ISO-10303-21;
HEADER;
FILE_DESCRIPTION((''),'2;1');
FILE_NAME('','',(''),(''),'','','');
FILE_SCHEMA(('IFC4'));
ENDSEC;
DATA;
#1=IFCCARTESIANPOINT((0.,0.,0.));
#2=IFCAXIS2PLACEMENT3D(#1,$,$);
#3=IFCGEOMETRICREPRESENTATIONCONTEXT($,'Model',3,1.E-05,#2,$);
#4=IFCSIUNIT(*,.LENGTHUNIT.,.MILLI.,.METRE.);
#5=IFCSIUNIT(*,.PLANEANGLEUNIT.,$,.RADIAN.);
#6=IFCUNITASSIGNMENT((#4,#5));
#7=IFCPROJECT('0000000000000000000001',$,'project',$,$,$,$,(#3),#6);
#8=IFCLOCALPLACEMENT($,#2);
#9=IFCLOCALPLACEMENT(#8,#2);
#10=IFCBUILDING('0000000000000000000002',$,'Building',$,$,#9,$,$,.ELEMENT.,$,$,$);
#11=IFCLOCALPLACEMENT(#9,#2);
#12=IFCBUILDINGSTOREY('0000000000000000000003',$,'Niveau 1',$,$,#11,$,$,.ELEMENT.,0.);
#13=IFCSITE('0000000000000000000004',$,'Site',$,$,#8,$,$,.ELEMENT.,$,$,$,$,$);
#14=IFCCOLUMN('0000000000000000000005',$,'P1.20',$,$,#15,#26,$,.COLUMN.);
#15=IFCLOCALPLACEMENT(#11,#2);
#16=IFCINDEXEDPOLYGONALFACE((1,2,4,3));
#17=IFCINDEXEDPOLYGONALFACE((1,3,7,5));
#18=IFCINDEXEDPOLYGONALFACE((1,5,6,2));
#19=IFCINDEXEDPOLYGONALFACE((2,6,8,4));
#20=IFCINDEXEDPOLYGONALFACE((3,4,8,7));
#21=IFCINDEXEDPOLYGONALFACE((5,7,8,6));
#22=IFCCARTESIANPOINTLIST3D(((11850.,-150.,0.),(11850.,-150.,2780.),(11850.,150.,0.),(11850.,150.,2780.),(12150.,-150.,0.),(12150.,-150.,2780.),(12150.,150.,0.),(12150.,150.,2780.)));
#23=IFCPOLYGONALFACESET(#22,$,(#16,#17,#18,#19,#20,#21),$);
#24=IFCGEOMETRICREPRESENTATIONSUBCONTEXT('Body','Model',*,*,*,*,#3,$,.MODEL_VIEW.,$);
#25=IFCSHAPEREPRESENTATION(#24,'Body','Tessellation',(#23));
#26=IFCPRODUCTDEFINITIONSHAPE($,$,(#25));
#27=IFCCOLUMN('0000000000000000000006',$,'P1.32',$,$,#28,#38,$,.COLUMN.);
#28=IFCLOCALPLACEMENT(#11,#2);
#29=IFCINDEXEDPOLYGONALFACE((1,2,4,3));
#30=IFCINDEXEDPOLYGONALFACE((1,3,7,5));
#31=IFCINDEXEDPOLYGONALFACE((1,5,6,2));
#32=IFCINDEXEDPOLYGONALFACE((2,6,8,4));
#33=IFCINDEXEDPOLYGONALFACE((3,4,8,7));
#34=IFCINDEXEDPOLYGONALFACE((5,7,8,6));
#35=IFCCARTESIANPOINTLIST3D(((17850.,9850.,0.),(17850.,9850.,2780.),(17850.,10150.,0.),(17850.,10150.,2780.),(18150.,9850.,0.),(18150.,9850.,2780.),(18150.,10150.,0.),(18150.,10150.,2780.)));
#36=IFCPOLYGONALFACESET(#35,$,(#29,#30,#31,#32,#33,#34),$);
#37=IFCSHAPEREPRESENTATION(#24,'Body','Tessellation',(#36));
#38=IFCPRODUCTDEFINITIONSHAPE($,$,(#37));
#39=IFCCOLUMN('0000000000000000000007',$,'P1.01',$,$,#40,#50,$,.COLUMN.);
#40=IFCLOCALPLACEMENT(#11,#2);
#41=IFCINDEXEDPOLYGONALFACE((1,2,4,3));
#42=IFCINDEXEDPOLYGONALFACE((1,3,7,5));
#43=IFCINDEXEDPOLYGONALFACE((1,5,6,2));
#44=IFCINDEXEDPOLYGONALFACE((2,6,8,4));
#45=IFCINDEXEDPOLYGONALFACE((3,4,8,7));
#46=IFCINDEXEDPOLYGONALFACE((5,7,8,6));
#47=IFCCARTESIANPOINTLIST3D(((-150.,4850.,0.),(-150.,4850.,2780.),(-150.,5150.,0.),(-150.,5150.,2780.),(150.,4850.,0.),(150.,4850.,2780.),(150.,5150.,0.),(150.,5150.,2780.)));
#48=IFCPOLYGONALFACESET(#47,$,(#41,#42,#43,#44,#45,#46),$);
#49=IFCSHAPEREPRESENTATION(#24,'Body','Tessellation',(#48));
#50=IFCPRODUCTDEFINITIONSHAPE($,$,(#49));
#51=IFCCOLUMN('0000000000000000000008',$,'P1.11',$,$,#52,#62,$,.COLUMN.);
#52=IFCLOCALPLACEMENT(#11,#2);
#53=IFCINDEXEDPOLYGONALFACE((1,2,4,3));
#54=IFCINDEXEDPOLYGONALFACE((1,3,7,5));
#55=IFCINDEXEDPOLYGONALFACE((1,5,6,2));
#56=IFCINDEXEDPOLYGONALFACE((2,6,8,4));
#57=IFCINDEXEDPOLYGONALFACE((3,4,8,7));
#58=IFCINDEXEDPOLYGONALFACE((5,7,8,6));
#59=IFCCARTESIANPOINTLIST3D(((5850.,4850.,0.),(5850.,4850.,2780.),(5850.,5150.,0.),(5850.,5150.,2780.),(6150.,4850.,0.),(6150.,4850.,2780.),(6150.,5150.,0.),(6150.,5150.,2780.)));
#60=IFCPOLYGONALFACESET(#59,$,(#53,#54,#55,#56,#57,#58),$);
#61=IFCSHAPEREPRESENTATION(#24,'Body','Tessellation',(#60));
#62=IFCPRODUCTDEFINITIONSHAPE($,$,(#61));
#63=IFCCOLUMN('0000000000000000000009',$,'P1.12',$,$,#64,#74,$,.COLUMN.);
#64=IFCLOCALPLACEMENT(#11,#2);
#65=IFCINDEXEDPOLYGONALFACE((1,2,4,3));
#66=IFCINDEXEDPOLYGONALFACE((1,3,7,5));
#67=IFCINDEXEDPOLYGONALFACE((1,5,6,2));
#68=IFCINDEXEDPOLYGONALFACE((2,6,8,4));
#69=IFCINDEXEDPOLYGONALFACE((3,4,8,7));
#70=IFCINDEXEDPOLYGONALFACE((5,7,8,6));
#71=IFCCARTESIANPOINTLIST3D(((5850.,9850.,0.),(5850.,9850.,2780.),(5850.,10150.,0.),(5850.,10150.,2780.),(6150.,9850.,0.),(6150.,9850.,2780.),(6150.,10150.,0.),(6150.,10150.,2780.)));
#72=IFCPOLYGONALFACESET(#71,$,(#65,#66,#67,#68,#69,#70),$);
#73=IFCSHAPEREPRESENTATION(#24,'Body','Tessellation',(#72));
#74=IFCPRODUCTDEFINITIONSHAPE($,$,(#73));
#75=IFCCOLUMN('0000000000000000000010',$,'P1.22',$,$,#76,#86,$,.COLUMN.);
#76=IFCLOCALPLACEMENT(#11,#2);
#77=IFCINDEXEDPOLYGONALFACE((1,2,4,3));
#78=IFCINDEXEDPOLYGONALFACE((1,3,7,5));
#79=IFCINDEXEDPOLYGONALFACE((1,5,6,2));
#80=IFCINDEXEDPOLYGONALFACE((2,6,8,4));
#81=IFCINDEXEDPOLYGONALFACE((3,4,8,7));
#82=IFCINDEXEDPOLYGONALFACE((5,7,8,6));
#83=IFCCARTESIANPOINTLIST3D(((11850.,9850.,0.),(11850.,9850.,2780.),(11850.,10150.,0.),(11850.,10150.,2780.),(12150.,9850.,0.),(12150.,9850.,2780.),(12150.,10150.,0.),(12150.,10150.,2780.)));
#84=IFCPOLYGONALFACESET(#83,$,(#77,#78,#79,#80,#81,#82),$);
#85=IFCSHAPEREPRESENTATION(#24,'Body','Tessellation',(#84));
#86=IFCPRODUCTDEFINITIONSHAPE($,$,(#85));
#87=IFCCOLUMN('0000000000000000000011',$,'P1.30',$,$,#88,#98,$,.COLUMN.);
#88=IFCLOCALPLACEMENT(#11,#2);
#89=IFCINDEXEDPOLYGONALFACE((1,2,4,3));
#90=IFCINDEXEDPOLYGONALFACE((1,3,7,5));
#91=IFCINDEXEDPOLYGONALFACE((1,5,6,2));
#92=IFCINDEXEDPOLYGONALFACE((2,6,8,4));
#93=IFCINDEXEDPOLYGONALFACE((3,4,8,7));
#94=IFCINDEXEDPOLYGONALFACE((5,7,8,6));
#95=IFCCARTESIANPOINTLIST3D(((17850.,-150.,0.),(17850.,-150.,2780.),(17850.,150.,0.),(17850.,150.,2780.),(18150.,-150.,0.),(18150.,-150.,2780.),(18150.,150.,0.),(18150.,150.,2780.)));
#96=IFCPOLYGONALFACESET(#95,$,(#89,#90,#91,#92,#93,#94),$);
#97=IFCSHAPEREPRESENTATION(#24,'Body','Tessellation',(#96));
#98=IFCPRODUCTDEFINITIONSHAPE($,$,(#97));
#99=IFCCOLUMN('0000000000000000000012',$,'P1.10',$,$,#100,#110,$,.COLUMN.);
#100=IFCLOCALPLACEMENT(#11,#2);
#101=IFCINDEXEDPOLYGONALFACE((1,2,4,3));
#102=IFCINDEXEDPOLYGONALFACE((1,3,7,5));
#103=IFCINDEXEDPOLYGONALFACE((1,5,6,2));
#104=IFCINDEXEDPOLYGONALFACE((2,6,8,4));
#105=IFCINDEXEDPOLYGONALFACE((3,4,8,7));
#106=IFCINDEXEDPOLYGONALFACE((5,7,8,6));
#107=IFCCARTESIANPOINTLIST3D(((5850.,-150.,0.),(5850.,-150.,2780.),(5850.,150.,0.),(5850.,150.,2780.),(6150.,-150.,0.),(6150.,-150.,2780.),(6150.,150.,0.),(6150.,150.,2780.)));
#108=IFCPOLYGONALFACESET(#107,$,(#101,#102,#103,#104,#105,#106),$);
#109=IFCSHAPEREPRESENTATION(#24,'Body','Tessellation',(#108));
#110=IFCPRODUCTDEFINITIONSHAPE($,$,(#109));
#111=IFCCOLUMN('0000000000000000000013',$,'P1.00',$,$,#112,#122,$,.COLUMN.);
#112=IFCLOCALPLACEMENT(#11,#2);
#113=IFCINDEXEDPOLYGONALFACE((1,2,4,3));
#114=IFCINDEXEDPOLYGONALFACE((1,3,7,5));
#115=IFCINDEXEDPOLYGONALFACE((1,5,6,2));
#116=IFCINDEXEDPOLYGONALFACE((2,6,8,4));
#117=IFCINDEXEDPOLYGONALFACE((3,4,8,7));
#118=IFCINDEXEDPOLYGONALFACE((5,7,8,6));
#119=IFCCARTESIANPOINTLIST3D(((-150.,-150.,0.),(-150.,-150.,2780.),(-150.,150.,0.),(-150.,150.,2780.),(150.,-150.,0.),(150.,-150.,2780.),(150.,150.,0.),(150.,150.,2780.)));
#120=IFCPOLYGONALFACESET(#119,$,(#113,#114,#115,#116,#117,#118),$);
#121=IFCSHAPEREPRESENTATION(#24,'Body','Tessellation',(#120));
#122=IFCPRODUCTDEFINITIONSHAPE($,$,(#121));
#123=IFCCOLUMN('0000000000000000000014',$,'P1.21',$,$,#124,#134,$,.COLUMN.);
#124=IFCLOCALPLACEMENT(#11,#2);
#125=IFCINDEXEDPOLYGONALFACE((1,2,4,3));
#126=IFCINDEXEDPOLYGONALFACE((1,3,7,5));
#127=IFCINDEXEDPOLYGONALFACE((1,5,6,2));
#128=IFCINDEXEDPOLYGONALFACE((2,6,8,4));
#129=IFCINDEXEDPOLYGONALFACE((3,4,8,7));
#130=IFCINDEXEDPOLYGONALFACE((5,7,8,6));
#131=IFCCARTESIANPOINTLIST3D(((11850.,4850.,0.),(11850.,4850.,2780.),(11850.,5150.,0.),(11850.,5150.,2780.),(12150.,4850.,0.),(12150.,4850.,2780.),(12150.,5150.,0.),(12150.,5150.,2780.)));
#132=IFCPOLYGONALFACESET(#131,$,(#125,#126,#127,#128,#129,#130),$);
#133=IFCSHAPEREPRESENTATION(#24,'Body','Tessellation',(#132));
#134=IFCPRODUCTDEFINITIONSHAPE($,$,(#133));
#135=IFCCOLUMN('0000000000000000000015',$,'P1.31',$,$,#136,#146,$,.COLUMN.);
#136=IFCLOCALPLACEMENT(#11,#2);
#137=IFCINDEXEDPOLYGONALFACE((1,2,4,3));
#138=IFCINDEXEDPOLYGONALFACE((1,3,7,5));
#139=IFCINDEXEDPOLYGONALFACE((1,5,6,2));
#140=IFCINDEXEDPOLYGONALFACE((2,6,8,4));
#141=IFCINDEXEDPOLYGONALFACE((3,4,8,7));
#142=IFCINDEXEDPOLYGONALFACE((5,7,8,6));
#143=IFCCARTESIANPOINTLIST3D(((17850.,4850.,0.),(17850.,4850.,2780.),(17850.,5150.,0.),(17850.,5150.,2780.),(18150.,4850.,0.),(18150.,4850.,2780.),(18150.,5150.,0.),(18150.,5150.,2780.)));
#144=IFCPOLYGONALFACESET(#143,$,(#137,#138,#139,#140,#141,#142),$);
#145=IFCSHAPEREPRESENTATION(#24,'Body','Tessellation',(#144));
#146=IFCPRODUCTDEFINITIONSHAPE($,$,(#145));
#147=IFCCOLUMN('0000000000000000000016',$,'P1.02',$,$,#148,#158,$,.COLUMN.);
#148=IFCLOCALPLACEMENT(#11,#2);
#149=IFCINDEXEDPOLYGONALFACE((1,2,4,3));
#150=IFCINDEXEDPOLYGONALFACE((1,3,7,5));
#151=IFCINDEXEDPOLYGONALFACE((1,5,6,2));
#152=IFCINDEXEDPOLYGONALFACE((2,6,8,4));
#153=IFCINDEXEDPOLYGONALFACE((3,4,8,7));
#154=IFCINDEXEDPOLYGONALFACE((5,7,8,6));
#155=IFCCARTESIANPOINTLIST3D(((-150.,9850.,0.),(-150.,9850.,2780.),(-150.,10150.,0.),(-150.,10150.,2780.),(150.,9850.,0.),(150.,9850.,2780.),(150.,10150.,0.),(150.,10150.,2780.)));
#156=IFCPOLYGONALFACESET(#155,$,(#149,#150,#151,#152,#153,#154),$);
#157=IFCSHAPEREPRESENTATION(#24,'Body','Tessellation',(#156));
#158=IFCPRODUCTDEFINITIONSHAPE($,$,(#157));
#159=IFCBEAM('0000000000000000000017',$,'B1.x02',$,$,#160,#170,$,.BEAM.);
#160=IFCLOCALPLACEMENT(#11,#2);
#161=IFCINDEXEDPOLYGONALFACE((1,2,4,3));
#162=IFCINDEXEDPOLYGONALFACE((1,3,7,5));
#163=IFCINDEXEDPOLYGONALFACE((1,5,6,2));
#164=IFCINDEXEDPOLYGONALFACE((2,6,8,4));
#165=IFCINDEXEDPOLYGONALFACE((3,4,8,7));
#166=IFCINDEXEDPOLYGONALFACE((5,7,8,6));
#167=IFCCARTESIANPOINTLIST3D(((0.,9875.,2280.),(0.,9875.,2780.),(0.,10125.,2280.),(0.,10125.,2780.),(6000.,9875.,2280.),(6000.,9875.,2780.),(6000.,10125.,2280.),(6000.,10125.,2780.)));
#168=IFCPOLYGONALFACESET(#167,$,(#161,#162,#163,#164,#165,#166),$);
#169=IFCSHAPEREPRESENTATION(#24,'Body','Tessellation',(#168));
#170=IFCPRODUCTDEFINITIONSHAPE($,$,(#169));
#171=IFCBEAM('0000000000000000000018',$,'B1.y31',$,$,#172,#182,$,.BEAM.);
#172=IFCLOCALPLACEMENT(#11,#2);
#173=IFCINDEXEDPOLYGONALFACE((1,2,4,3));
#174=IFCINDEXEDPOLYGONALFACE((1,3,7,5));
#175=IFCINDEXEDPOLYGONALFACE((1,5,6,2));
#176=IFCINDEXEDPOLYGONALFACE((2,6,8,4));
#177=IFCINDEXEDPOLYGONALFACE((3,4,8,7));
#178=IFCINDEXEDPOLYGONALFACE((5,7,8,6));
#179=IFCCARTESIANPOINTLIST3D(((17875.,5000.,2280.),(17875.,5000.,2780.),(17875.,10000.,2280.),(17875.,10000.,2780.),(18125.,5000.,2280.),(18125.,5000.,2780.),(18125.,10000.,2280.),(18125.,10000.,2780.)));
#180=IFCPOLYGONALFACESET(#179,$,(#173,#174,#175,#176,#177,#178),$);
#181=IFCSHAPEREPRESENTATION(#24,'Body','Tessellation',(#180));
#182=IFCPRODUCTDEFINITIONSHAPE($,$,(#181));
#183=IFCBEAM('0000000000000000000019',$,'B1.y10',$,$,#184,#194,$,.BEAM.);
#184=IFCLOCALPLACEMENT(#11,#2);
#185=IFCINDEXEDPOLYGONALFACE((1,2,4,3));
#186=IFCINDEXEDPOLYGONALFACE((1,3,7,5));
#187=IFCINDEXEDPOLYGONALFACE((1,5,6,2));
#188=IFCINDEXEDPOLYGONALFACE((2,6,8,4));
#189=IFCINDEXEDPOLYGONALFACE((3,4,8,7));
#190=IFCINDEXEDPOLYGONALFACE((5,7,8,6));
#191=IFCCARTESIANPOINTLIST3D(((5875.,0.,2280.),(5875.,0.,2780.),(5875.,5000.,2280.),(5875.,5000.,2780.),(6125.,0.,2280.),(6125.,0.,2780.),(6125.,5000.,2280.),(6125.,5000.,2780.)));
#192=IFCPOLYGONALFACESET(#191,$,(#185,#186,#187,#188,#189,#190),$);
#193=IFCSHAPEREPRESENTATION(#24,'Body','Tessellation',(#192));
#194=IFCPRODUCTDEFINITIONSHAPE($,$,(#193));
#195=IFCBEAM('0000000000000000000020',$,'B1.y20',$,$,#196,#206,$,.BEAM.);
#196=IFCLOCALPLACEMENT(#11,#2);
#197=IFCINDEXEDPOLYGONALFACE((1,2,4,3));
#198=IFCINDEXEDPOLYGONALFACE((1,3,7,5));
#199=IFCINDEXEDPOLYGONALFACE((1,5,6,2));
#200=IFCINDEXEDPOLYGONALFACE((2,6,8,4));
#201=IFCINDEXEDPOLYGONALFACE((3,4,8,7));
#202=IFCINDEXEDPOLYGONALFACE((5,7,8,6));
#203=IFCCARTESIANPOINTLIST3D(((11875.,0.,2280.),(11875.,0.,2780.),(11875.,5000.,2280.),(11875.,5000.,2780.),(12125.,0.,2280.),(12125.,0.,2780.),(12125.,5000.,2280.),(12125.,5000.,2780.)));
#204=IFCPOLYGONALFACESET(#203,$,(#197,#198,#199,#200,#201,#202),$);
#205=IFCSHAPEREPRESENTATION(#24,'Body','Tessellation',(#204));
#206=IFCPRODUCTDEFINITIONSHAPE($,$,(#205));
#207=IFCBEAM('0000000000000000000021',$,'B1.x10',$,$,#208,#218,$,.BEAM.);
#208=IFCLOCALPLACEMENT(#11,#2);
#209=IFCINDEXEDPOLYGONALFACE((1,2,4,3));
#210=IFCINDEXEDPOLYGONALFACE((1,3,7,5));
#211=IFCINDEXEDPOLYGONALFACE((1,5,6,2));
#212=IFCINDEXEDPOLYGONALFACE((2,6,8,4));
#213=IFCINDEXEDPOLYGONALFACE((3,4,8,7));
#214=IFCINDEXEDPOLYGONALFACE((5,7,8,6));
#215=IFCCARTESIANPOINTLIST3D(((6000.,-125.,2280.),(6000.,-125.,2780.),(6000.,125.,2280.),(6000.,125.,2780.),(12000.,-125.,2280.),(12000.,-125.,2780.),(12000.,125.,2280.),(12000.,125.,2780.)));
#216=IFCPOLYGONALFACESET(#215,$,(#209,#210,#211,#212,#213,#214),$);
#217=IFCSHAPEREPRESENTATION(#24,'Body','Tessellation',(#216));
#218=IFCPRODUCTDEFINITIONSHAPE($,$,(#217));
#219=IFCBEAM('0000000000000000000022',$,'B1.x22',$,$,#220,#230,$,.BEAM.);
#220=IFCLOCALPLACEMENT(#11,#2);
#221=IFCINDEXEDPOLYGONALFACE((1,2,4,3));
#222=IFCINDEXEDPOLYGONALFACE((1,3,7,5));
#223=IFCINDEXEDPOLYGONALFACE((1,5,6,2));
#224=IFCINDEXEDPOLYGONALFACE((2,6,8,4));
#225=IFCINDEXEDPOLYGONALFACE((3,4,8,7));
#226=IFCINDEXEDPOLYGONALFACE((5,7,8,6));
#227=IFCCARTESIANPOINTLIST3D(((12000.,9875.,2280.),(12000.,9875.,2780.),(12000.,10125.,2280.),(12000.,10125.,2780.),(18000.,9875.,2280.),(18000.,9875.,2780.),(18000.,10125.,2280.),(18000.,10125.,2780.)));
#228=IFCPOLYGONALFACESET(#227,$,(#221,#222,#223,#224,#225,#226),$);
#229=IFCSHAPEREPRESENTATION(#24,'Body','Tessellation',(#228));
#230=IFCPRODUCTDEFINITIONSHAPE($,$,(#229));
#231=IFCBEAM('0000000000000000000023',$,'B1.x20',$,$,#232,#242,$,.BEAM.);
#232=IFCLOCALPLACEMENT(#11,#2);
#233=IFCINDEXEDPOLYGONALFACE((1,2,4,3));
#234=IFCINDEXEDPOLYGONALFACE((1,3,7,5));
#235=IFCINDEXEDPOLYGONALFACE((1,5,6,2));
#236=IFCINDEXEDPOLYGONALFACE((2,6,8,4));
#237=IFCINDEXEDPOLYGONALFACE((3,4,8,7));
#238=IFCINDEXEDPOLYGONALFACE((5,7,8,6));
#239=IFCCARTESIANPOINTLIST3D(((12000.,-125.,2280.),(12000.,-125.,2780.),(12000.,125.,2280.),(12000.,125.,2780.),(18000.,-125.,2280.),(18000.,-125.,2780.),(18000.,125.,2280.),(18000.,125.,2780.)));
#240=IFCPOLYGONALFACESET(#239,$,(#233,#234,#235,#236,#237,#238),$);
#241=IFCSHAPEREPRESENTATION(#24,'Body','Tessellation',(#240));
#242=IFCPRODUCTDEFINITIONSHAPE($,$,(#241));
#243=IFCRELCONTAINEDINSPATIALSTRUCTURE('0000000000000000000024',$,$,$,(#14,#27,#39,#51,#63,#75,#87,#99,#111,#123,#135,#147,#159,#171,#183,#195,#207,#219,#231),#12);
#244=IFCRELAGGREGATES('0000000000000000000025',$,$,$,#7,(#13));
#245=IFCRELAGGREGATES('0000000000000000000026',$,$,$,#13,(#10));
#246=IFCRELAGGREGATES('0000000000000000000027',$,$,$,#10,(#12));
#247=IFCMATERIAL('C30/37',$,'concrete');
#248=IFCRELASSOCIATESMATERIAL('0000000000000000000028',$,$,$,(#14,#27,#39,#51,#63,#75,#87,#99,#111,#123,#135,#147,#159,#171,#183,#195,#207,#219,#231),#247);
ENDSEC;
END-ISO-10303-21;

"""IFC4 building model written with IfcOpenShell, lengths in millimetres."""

from ifc_helpers import new_model, si_unit, frame, origin, place, context, subcontext, project, spatial, rectangle, extrude, material, element, save


model = new_model("IFC4")

# Units and contexts
model_context = context("Model", 3, precision=1e-05, world=origin())
body_context = subcontext(model_context, "Body", "Model", "MODEL_VIEW")
ifc_project = project(units=[si_unit("LENGTHUNIT", "METRE", prefix="MILLI"), si_unit("PLANEANGLEUNIT", "RADIAN")], contexts=[model_context])

# Site, building, storey
site_placement = place(None, origin())
site = spatial("IfcSite", under=ifc_project, at=site_placement, Name="Site", CompositionType="ELEMENT")
building_placement = place(site_placement, origin())
building = spatial("IfcBuilding", under=site, at=building_placement, Name="Building", CompositionType="ELEMENT")
storey_placement = place(building_placement, origin())
storey = spatial("IfcBuildingStorey", under=building, at=storey_placement, Name="Niveau 1", CompositionType="ELEMENT", Elevation=0.0)

# Columns
ifc_material = material(Name="C30/37", Category="concrete")
for number, where, z_axis, x_axis, name in (
    (1, (12000.0, 0.0, 0.0), (0.0, 0.0, 1.0), (1.0, 0.0, 0.0), "P1.20"),
    (2, (18000.0, 10000.0, 0.0), (0.0, 0.0, 1.0), (1.0, 0.0, 0.0), "P1.32"),
    (3, (0.0, 5000.0, 0.0), (0.0, 0.0, 1.0), (1.0, 0.0, 0.0), "P1.01"),
    (4, (6000.0, 5000.0, 0.0), (0.0, 0.0, 1.0), (1.0, 0.0, 0.0), "P1.11"),
    (5, (6000.0, 10000.0, 0.0), (0.0, 0.0, 1.0), (1.0, 0.0, 0.0), "P1.12"),
    (6, (12000.0, 10000.0, 0.0), (0.0, 0.0, 1.0), (1.0, 0.0, 0.0), "P1.22"),
    (7, (18000.0, 0.0, 0.0), (0.0, 0.0, 1.0), (1.0, 0.0, 0.0), "P1.30"),
    (8, (6000.0, 0.0, 0.0), (0.0, 0.0, 1.0), (1.0, 0.0, 0.0), "P1.10"),
    (9, (0.0, 0.0, 0.0), (0.0, 0.0, 1.0), (1.0, 0.0, 0.0), "P1.00"),
    (10, (12000.0, 5000.0, 0.0), (0.0, 0.0, 1.0), (1.0, 0.0, 0.0), "P1.21"),
    (11, (18000.0, 5000.0, 0.0), (0.0, 0.0, 1.0), (1.0, 0.0, 0.0), "P1.31"),
    (12, (0.0, 10000.0, 0.0), (0.0, 0.0, 1.0), (1.0, 0.0, 0.0), "P1.02"),
):
    element("IfcColumn", number, at=place(storey_placement, frame(where, z_axis=z_axis, x_axis=x_axis)), inside=storey, material=ifc_material, Name=name, PredefinedType="COLUMN", context=body_context, shape_type="SweptSolid", body=[
        extrude(rectangle(XDim=300.0, YDim=300.0), origin(), (0.0, 0.0, 1.0), 2780.0),
    ])

# Beams
beam_1_placement = place(storey_placement, frame((0.0, 10000.0, 2530.0), z_axis=(1.0, 0.0, 0.0), x_axis=(0.0, 1.0, 0.0)))
element("IfcBeam", 13, at=beam_1_placement, inside=storey, material=ifc_material, Name="B1.x02", PredefinedType="BEAM", context=body_context, shape_type="SweptSolid", body=[
    extrude(rectangle(XDim=250.0, YDim=500.0), origin(), (0.0, 0.0, 1.0), 6000.0),
])
for number, where, z_axis, x_axis, name in (
    (14, (18000.0, 5000.0, 2530.0), (0.0, 1.0, 0.0), (-1.0, 0.0, 0.0), "B1.y31"),
    (15, (6000.0, 0.0, 2530.0), (0.0, 1.0, 0.0), (-1.0, 0.0, 0.0), "B1.y10"),
    (16, (12000.0, 0.0, 2530.0), (0.0, 1.0, 0.0), (-1.0, 0.0, 0.0), "B1.y20"),
):
    element("IfcBeam", number, at=place(storey_placement, frame(where, z_axis=z_axis, x_axis=x_axis)), inside=storey, material=ifc_material, Name=name, PredefinedType="BEAM", context=body_context, shape_type="SweptSolid", body=[
        extrude(rectangle(XDim=250.0, YDim=500.0), origin(), (0.0, 0.0, 1.0), 5000.0),
    ])
for number, where, z_axis, x_axis, name in (
    (17, (6000.0, 0.0, 2530.0), (1.0, 0.0, 0.0), (0.0, 1.0, 0.0), "B1.x10"),
    (18, (12000.0, 10000.0, 2530.0), (1.0, 0.0, 0.0), (0.0, 1.0, 0.0), "B1.x22"),
    (19, (12000.0, 0.0, 2530.0), (1.0, 0.0, 0.0), (0.0, 1.0, 0.0), "B1.x20"),
):
    element("IfcBeam", number, at=place(storey_placement, frame(where, z_axis=z_axis, x_axis=x_axis)), inside=storey, material=ifc_material, Name=name, PredefinedType="BEAM", context=body_context, shape_type="SweptSolid", body=[
        extrude(rectangle(XDim=250.0, YDim=500.0), origin(), (0.0, 0.0, 1.0), 6000.0),
    ])

save(model, "model.ifc")
